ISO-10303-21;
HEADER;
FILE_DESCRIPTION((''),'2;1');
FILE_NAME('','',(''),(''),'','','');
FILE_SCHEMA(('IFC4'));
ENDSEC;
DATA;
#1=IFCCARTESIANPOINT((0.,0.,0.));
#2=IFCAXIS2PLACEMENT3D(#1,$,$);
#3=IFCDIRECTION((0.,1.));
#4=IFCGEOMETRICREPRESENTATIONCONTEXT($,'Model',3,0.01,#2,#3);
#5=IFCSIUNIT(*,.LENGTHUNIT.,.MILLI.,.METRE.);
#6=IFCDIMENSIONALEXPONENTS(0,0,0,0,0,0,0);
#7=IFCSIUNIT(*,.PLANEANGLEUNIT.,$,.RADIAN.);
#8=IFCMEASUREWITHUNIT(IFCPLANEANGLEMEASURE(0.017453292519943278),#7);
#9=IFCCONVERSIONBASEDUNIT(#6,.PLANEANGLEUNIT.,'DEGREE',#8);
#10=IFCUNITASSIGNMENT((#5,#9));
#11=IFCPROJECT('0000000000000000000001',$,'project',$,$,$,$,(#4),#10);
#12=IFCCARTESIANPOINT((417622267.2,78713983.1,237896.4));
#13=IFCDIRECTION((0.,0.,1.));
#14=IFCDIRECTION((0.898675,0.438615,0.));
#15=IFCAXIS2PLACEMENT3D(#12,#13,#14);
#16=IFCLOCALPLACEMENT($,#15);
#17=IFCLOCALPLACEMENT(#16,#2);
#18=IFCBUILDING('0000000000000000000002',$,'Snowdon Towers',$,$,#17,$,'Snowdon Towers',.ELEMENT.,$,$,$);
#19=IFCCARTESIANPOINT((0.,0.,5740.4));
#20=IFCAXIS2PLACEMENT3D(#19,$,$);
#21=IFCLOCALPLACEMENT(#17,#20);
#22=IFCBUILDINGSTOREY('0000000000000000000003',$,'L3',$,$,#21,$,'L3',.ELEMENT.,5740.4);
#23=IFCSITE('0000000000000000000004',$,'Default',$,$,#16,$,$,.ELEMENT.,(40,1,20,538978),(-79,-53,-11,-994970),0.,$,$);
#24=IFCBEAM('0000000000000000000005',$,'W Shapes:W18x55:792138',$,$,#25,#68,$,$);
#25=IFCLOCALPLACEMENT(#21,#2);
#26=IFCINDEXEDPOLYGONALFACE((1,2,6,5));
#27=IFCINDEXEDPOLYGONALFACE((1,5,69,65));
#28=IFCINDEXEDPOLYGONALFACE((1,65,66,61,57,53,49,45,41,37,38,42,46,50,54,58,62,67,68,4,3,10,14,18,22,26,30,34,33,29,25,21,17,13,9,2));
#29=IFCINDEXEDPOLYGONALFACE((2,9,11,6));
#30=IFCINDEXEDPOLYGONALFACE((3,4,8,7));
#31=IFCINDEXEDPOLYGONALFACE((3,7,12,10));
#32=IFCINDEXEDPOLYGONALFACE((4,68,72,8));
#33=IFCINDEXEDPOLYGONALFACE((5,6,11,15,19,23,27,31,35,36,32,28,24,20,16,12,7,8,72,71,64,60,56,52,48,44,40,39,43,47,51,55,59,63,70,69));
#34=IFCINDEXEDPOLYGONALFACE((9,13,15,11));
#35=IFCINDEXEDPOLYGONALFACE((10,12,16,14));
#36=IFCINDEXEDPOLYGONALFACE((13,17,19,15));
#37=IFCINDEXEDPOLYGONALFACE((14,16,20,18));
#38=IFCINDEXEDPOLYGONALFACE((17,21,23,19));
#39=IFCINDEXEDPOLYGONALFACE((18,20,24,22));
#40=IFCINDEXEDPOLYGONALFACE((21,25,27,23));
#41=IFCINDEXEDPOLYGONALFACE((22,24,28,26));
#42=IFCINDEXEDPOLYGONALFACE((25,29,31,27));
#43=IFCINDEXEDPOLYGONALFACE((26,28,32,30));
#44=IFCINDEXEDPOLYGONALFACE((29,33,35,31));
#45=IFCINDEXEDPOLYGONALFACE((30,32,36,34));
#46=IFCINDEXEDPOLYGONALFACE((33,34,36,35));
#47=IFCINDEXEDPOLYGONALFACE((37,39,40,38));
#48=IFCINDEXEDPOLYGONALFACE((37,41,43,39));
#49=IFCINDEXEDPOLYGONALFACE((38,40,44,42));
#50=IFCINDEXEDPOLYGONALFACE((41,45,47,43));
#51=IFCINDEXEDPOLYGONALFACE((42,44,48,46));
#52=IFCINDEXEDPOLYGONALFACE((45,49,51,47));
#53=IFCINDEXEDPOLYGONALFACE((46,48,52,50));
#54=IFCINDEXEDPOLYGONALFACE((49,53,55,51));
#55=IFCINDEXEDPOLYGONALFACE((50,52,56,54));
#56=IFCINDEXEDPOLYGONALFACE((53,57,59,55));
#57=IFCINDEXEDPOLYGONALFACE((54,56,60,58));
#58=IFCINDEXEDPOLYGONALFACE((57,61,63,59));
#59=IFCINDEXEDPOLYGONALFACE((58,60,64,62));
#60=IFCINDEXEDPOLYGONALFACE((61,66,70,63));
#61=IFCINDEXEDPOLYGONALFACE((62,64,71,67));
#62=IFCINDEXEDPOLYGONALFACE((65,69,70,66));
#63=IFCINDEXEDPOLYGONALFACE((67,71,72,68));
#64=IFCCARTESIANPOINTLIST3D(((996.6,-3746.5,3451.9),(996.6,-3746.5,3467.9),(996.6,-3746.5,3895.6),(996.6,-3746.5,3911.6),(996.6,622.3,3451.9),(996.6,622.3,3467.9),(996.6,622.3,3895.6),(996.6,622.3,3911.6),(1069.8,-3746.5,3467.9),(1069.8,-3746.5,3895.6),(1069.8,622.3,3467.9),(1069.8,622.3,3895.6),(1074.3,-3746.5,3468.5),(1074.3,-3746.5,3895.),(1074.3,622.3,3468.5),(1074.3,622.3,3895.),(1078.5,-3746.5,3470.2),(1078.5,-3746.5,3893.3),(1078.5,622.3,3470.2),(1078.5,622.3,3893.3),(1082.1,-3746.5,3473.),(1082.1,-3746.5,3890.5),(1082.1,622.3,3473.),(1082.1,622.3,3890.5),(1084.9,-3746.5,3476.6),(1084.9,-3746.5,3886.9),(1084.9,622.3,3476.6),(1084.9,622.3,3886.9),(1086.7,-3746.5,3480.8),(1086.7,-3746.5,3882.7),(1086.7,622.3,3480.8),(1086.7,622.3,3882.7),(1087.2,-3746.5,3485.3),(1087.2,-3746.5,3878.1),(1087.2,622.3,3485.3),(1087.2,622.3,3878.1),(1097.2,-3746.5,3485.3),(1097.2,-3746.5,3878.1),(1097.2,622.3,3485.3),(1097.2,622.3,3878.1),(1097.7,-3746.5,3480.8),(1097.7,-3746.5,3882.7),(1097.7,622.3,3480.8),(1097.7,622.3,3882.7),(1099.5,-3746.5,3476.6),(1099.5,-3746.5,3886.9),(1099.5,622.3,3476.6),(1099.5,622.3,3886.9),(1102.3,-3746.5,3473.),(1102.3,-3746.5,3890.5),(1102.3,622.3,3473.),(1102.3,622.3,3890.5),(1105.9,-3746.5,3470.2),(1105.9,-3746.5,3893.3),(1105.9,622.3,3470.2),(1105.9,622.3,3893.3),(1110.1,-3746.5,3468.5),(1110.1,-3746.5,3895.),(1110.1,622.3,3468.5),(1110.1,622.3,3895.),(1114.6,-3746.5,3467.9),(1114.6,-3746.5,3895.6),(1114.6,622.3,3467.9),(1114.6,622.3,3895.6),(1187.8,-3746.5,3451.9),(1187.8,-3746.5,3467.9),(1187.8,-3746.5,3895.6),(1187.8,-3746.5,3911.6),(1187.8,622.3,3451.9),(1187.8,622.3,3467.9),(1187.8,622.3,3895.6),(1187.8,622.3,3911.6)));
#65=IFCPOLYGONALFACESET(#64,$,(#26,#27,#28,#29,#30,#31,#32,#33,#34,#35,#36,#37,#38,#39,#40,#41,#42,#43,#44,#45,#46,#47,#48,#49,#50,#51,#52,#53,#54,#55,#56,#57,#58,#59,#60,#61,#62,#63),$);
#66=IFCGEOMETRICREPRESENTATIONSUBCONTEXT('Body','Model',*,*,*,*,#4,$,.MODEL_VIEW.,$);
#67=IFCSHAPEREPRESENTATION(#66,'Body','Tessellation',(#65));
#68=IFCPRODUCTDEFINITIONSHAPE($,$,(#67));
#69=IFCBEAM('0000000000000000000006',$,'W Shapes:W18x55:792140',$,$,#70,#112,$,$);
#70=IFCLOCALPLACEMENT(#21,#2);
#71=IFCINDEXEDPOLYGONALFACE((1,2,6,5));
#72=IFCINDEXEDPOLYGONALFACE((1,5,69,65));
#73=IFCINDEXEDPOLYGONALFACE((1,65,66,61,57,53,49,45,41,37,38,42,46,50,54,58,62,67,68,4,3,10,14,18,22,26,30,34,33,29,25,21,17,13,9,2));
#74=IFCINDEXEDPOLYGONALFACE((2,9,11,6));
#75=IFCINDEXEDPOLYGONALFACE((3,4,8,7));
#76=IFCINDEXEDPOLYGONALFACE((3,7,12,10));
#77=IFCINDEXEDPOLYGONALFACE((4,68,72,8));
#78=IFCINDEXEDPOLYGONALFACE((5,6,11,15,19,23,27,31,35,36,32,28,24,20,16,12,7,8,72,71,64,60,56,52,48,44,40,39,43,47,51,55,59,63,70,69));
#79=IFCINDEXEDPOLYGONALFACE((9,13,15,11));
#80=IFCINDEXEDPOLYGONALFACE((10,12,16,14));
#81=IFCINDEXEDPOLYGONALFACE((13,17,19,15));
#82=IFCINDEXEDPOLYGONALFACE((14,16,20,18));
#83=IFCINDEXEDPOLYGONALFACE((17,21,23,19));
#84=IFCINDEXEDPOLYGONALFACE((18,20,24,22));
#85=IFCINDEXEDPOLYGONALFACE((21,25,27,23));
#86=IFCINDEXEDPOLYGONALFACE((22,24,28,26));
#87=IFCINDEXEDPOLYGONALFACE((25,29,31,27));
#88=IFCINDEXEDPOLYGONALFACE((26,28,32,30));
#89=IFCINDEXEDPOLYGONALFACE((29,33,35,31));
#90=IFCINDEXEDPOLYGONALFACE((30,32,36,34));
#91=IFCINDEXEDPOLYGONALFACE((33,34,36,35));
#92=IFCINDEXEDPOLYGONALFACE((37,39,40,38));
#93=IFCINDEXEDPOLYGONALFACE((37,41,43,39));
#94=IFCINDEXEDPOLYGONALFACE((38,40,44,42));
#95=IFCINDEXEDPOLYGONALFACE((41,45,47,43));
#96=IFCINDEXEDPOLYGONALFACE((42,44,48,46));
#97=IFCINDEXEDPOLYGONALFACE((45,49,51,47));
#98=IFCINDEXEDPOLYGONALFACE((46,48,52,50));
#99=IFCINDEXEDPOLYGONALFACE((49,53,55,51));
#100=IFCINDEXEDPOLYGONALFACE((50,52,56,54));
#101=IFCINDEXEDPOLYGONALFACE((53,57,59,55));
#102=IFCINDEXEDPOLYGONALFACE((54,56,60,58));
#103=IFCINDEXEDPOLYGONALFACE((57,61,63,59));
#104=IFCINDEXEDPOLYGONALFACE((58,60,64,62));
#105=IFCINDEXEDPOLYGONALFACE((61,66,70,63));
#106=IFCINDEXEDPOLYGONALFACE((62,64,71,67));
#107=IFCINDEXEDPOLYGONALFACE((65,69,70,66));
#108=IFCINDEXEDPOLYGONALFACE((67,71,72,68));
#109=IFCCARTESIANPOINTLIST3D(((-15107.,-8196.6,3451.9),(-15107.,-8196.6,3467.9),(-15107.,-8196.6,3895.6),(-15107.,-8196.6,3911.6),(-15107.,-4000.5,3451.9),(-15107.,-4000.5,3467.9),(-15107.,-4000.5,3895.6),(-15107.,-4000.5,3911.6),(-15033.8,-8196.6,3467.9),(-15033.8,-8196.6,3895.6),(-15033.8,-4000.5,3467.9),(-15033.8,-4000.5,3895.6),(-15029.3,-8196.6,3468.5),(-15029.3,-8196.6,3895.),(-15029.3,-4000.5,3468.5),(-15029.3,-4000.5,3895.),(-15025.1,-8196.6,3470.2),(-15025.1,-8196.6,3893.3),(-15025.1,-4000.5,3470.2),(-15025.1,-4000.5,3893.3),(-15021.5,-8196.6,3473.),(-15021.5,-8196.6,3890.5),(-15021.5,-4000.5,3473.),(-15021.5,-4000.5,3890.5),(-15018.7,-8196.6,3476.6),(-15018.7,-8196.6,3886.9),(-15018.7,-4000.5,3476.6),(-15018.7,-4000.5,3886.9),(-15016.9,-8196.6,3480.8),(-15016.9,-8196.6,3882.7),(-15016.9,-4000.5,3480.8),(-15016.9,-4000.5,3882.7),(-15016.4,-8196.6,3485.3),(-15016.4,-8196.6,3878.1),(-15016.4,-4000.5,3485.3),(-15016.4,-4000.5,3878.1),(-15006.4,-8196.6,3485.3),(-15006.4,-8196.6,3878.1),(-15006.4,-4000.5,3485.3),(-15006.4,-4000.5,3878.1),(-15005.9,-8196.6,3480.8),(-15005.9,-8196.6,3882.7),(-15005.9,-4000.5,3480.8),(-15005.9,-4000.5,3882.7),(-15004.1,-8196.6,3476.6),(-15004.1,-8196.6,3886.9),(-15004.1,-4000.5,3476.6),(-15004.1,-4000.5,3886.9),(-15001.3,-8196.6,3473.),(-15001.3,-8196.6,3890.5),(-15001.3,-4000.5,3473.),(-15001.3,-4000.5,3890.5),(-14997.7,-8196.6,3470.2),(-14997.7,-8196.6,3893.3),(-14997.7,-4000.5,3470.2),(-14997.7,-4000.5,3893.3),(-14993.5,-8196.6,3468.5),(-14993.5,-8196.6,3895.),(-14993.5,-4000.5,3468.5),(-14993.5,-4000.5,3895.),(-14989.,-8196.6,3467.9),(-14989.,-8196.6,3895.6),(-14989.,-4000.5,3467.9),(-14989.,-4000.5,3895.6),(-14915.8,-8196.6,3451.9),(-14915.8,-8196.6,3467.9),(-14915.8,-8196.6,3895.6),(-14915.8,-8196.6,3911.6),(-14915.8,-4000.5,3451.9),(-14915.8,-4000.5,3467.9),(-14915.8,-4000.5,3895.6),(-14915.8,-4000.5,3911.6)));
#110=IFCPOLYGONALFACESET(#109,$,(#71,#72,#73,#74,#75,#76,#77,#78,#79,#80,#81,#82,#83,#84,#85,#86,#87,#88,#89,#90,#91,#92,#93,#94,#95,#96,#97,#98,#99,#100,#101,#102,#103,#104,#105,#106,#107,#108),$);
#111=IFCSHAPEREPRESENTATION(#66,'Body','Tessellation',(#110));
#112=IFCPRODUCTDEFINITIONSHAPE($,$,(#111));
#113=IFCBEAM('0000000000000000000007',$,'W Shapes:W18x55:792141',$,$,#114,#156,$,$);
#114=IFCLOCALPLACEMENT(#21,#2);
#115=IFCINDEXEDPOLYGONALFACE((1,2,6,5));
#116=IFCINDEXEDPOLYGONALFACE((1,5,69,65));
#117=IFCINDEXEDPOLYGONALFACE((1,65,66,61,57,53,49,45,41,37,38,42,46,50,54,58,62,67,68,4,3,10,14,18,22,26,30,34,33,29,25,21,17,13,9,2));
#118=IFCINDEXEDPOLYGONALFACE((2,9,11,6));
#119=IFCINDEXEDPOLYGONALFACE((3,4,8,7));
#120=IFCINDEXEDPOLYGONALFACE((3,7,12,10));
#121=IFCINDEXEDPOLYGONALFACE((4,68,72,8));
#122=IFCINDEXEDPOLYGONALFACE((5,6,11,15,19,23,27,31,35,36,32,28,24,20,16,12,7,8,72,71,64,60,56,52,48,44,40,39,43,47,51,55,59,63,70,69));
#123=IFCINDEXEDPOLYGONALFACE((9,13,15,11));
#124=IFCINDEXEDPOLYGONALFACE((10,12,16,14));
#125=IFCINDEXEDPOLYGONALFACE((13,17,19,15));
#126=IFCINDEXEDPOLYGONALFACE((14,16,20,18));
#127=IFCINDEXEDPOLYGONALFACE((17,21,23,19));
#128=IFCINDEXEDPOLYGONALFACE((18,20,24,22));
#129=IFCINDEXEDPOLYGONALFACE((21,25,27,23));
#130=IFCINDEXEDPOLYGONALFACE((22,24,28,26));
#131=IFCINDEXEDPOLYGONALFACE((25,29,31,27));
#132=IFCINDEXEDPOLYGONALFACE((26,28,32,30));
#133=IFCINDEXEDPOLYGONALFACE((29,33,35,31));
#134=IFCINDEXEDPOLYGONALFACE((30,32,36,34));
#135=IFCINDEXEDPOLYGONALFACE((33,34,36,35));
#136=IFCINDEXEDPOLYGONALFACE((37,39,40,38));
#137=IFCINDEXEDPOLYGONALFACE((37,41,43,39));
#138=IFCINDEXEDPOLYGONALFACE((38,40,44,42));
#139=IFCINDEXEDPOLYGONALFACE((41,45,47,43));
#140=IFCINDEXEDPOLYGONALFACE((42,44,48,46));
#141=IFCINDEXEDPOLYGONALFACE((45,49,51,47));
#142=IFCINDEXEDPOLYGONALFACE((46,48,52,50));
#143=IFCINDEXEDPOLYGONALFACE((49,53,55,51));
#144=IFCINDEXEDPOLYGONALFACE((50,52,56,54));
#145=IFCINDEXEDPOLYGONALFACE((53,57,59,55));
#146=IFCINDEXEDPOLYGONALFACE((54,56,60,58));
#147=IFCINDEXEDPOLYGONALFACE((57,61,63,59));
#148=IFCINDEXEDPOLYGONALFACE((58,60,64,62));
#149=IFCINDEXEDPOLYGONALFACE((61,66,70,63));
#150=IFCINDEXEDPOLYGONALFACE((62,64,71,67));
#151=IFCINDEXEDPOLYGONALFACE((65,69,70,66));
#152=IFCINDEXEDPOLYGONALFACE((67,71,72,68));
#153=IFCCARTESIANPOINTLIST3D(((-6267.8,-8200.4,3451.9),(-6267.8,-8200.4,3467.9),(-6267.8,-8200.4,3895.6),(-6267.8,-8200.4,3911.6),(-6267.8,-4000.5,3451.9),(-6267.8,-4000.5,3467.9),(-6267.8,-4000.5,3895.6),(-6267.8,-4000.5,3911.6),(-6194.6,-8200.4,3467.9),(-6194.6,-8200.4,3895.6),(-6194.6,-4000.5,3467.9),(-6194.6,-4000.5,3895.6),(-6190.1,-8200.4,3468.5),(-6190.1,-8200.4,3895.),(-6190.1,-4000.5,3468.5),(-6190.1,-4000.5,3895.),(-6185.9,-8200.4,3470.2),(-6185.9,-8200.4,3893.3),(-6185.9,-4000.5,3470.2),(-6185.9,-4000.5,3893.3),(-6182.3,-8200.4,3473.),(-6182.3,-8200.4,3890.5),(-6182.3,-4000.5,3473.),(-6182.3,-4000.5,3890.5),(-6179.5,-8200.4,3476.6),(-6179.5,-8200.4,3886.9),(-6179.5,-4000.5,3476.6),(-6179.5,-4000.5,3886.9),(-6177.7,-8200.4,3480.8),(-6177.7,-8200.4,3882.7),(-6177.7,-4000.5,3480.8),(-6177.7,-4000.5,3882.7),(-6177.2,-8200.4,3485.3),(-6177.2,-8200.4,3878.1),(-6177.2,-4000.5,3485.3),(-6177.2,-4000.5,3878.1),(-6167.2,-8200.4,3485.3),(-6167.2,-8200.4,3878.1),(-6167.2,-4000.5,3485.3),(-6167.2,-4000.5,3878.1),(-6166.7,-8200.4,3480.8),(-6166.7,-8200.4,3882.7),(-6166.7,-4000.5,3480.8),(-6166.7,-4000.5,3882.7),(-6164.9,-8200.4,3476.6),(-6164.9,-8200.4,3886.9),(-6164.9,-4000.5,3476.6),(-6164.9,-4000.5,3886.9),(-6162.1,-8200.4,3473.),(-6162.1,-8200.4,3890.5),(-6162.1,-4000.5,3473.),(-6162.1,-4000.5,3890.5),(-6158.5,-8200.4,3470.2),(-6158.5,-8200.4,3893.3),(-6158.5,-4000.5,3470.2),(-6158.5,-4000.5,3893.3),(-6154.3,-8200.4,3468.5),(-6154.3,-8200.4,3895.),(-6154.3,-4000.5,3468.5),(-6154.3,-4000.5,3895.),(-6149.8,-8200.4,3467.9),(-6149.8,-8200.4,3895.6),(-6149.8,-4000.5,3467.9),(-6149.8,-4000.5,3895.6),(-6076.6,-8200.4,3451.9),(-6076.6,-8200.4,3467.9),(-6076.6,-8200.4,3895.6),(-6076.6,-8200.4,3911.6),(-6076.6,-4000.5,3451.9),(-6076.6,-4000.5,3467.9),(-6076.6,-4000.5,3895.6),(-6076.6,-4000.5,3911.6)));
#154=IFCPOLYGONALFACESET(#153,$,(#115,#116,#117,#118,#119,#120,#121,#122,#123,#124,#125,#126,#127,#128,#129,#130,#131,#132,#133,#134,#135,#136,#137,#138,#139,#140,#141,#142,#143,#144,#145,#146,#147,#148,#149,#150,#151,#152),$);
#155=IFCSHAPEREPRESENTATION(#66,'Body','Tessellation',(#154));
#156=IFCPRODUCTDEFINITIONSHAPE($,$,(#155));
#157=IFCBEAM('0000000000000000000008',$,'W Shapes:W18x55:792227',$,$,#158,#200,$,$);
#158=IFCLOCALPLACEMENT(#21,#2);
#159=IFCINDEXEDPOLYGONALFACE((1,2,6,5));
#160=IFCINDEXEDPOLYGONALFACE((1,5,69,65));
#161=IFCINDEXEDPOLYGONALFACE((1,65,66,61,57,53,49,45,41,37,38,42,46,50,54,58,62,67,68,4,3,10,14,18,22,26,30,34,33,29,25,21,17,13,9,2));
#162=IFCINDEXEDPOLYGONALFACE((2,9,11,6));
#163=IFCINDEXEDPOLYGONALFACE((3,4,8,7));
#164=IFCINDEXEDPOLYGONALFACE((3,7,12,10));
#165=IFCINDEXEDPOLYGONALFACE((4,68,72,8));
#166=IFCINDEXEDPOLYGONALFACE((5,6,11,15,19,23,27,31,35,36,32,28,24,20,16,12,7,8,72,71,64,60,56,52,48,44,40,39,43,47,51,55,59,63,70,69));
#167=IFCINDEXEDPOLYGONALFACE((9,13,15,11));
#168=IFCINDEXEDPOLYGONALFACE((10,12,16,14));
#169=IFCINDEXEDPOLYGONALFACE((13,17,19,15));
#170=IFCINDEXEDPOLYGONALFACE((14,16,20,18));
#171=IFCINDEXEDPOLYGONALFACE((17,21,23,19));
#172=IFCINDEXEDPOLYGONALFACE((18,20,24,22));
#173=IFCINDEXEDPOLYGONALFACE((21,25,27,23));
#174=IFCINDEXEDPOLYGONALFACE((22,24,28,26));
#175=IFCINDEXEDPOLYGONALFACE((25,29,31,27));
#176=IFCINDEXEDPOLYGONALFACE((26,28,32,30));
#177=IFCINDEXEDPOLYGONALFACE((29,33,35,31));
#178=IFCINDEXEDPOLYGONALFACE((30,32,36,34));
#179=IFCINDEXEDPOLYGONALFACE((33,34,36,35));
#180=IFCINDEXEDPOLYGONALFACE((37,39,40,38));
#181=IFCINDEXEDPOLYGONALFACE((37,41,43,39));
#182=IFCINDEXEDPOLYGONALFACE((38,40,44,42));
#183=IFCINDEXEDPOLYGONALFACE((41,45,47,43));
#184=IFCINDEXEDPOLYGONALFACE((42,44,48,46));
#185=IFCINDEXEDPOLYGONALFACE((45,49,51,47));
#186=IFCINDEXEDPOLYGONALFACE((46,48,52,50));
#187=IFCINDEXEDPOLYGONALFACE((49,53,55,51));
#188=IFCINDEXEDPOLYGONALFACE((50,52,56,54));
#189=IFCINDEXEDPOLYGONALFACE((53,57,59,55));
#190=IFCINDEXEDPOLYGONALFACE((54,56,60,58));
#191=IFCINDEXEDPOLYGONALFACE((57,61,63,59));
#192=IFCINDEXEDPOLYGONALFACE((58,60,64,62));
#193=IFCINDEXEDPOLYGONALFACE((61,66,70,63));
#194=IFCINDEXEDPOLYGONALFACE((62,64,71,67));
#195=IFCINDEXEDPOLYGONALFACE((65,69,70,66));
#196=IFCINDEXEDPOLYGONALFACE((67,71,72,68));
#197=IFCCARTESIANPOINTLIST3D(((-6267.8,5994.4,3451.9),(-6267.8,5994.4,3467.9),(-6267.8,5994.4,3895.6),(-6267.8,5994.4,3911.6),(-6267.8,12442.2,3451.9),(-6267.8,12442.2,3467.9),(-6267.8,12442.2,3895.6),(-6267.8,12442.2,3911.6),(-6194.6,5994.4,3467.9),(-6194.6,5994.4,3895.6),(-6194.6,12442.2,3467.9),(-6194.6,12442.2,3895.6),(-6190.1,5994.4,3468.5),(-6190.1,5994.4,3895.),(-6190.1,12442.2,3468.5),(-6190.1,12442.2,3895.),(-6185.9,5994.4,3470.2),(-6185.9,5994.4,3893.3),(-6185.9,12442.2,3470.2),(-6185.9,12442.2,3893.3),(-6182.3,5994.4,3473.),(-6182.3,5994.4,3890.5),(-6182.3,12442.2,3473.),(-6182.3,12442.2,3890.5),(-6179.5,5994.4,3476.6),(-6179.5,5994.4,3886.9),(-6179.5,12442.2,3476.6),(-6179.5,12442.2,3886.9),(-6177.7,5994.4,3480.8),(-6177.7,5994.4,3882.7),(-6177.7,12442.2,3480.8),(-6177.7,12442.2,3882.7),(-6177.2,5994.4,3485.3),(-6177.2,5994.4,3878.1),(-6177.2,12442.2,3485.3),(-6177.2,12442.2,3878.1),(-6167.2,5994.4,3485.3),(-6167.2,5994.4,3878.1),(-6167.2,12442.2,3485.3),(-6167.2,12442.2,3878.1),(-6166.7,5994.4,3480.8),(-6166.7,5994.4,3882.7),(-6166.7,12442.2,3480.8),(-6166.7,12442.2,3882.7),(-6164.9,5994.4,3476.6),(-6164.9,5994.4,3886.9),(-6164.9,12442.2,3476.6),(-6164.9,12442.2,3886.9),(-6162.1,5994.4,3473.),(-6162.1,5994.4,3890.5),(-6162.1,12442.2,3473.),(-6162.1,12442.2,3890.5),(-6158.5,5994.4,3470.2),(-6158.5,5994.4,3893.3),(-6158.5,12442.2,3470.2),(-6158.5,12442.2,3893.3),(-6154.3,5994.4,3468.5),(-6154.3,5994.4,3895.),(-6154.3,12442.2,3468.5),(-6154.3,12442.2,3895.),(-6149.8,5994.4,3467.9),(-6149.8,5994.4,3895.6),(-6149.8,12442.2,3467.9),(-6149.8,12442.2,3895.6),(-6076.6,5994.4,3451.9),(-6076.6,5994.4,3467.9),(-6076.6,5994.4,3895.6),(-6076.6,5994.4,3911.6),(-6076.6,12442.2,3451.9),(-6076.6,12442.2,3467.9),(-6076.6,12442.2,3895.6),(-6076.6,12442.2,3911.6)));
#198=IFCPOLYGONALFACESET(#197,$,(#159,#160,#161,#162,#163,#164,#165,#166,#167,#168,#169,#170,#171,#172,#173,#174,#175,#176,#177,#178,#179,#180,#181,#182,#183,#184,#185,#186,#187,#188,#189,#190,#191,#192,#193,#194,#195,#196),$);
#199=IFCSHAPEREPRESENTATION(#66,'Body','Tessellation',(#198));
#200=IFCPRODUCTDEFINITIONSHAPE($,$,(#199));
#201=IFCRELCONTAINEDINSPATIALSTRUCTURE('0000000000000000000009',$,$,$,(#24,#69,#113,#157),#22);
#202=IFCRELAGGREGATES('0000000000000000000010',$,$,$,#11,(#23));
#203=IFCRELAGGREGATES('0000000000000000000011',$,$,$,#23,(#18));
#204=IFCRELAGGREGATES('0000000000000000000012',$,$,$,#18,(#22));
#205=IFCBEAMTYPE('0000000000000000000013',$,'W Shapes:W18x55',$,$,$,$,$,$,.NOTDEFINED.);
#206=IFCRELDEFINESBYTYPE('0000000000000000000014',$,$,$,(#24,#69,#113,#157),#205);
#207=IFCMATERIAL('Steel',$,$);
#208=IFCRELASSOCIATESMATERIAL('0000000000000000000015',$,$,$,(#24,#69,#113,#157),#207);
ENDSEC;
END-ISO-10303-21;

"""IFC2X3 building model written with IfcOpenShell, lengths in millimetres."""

from ifc_helpers import new_model, entity, si_unit, converted_unit, direction, frame, frame_2d, origin, place, context, subcontext, project, spatial, i_section, extrude, material, type_object, element, save


model = new_model("IFC2X3")

# Units and contexts
model_context = context("Model", 3, precision=0.01, world=origin(), true_north=direction((0.0, 1.0)))
body_context = subcontext(model_context, "Body", "Model", "MODEL_VIEW")
ifc_project = project(units=[si_unit("LENGTHUNIT", "METRE", prefix="MILLI"), converted_unit("PLANEANGLEUNIT", "DEGREE", entity("IfcPlaneAngleMeasure", 0.017453292519943278), si_unit("PLANEANGLEUNIT", "RADIAN"), dimensions=[0, 0, 0, 0, 0, 0, 0])], contexts=[model_context])

# Site, building, storey
site_placement = place(None, frame((417622267.2, 78713983.1, 237896.4), z_axis=(0.0, 0.0, 1.0), x_axis=(0.898675, 0.438615, 0.0)))
site = spatial("IfcSite", under=ifc_project, at=site_placement, Name="Default", CompositionType="ELEMENT", RefLatitude=(40, 1, 20, 538978), RefLongitude=(-79, -53, -11, -994970), RefElevation=0.0)
building_placement = place(site_placement, origin())
building = spatial("IfcBuilding", under=site, at=building_placement, Name="Snowdon Towers", LongName="Snowdon Towers", CompositionType="ELEMENT")
storey_placement = place(building_placement, frame((0.0, 0.0, 5740.4)))
storey = spatial("IfcBuildingStorey", under=building, at=storey_placement, Name="L3", LongName="L3", CompositionType="ELEMENT", Elevation=5740.4)

# Shared definitions
ifc_material_1 = material(Name="Steel")

# Beams
beam_type = type_object("IfcBeamType", Name="W Shapes:W18x55", PredefinedType="NOTDEFINED")
beam_1_placement = place(storey_placement, frame((1092.2, 762.0, 3911.6), z_axis=(0.0, 0.0, 1.0), x_axis=(0.0, -1.0, 0.0)))
element("IfcBeam", 1, at=beam_1_placement, inside=storey, type_object=beam_type, material=ifc_material_1, Name="W Shapes:W18x55:792138", context=body_context, shape_type="SweptSolid", body=[
    extrude(i_section(OverallWidth=191.3, OverallDepth=459.7, WebThickness=9.9, FlangeThickness=16.0, FilletRadius=17.5, at=frame_2d((0.0, 0.0), x_axis=(0.0, 1.0))), frame((139.7, 0.0, -229.9), z_axis=(1.0, 0.0, 0.0), x_axis=(0.0, 0.0, -1.0)), (0.0, 0.0, 1.0), 4368.8),
])
beam_2_placement = place(storey_placement, frame((-15011.4, -3873.5, 3911.6), z_axis=(0.0, 0.0, 1.0), x_axis=(0.0, -1.0, 0.0)))
element("IfcBeam", 2, at=beam_2_placement, inside=storey, type_object=beam_type, material=ifc_material_1, Name="W Shapes:W18x55:792140", context=body_context, shape_type="SweptSolid", body=[
    extrude(i_section(OverallWidth=191.3, OverallDepth=459.7, WebThickness=9.9, FlangeThickness=16.0, FilletRadius=17.5, at=frame_2d((0.0, 0.0), x_axis=(0.0, 1.0))), frame((127.0, 0.0, -229.9), z_axis=(1.0, 0.0, 0.0), x_axis=(0.0, 0.0, -1.0)), (0.0, 0.0, 1.0), 4196.1),
])
beam_3_placement = place(storey_placement, frame((-6172.2, -3873.5, 3911.6), z_axis=(0.0, 0.0, 1.0), x_axis=(0.0, -1.0, 0.0)))
element("IfcBeam", 3, at=beam_3_placement, inside=storey, type_object=beam_type, material=ifc_material_1, Name="W Shapes:W18x55:792141", context=body_context, shape_type="SweptSolid", body=[
    extrude(i_section(OverallWidth=191.3, OverallDepth=459.7, WebThickness=9.9, FlangeThickness=16.0, FilletRadius=17.5, at=frame_2d((0.0, 0.0), x_axis=(0.0, 1.0))), frame((127.0, 0.0, -229.9), z_axis=(1.0, 0.0, 0.0), x_axis=(0.0, 0.0, -1.0)), (0.0, 0.0, 1.0), 4199.9),
])
beam_4_placement = place(storey_placement, frame((-6172.2, 12636.5, 3911.6), z_axis=(0.0, 0.0, 1.0), x_axis=(0.0, -1.0, 0.0)))
element("IfcBeam", 4, at=beam_4_placement, inside=storey, type_object=beam_type, material=ifc_material_1, Name="W Shapes:W18x55:792227", context=body_context, shape_type="SweptSolid", body=[
    extrude(i_section(OverallWidth=191.3, OverallDepth=459.7, WebThickness=9.9, FlangeThickness=16.0, FilletRadius=17.5, at=frame_2d((0.0, 0.0), x_axis=(0.0, 1.0))), frame((194.3, 0.0, -229.9), z_axis=(1.0, 0.0, 0.0), x_axis=(0.0, 0.0, -1.0)), (0.0, 0.0, 1.0), 6447.8),
])

save(model, "model.ifc")
